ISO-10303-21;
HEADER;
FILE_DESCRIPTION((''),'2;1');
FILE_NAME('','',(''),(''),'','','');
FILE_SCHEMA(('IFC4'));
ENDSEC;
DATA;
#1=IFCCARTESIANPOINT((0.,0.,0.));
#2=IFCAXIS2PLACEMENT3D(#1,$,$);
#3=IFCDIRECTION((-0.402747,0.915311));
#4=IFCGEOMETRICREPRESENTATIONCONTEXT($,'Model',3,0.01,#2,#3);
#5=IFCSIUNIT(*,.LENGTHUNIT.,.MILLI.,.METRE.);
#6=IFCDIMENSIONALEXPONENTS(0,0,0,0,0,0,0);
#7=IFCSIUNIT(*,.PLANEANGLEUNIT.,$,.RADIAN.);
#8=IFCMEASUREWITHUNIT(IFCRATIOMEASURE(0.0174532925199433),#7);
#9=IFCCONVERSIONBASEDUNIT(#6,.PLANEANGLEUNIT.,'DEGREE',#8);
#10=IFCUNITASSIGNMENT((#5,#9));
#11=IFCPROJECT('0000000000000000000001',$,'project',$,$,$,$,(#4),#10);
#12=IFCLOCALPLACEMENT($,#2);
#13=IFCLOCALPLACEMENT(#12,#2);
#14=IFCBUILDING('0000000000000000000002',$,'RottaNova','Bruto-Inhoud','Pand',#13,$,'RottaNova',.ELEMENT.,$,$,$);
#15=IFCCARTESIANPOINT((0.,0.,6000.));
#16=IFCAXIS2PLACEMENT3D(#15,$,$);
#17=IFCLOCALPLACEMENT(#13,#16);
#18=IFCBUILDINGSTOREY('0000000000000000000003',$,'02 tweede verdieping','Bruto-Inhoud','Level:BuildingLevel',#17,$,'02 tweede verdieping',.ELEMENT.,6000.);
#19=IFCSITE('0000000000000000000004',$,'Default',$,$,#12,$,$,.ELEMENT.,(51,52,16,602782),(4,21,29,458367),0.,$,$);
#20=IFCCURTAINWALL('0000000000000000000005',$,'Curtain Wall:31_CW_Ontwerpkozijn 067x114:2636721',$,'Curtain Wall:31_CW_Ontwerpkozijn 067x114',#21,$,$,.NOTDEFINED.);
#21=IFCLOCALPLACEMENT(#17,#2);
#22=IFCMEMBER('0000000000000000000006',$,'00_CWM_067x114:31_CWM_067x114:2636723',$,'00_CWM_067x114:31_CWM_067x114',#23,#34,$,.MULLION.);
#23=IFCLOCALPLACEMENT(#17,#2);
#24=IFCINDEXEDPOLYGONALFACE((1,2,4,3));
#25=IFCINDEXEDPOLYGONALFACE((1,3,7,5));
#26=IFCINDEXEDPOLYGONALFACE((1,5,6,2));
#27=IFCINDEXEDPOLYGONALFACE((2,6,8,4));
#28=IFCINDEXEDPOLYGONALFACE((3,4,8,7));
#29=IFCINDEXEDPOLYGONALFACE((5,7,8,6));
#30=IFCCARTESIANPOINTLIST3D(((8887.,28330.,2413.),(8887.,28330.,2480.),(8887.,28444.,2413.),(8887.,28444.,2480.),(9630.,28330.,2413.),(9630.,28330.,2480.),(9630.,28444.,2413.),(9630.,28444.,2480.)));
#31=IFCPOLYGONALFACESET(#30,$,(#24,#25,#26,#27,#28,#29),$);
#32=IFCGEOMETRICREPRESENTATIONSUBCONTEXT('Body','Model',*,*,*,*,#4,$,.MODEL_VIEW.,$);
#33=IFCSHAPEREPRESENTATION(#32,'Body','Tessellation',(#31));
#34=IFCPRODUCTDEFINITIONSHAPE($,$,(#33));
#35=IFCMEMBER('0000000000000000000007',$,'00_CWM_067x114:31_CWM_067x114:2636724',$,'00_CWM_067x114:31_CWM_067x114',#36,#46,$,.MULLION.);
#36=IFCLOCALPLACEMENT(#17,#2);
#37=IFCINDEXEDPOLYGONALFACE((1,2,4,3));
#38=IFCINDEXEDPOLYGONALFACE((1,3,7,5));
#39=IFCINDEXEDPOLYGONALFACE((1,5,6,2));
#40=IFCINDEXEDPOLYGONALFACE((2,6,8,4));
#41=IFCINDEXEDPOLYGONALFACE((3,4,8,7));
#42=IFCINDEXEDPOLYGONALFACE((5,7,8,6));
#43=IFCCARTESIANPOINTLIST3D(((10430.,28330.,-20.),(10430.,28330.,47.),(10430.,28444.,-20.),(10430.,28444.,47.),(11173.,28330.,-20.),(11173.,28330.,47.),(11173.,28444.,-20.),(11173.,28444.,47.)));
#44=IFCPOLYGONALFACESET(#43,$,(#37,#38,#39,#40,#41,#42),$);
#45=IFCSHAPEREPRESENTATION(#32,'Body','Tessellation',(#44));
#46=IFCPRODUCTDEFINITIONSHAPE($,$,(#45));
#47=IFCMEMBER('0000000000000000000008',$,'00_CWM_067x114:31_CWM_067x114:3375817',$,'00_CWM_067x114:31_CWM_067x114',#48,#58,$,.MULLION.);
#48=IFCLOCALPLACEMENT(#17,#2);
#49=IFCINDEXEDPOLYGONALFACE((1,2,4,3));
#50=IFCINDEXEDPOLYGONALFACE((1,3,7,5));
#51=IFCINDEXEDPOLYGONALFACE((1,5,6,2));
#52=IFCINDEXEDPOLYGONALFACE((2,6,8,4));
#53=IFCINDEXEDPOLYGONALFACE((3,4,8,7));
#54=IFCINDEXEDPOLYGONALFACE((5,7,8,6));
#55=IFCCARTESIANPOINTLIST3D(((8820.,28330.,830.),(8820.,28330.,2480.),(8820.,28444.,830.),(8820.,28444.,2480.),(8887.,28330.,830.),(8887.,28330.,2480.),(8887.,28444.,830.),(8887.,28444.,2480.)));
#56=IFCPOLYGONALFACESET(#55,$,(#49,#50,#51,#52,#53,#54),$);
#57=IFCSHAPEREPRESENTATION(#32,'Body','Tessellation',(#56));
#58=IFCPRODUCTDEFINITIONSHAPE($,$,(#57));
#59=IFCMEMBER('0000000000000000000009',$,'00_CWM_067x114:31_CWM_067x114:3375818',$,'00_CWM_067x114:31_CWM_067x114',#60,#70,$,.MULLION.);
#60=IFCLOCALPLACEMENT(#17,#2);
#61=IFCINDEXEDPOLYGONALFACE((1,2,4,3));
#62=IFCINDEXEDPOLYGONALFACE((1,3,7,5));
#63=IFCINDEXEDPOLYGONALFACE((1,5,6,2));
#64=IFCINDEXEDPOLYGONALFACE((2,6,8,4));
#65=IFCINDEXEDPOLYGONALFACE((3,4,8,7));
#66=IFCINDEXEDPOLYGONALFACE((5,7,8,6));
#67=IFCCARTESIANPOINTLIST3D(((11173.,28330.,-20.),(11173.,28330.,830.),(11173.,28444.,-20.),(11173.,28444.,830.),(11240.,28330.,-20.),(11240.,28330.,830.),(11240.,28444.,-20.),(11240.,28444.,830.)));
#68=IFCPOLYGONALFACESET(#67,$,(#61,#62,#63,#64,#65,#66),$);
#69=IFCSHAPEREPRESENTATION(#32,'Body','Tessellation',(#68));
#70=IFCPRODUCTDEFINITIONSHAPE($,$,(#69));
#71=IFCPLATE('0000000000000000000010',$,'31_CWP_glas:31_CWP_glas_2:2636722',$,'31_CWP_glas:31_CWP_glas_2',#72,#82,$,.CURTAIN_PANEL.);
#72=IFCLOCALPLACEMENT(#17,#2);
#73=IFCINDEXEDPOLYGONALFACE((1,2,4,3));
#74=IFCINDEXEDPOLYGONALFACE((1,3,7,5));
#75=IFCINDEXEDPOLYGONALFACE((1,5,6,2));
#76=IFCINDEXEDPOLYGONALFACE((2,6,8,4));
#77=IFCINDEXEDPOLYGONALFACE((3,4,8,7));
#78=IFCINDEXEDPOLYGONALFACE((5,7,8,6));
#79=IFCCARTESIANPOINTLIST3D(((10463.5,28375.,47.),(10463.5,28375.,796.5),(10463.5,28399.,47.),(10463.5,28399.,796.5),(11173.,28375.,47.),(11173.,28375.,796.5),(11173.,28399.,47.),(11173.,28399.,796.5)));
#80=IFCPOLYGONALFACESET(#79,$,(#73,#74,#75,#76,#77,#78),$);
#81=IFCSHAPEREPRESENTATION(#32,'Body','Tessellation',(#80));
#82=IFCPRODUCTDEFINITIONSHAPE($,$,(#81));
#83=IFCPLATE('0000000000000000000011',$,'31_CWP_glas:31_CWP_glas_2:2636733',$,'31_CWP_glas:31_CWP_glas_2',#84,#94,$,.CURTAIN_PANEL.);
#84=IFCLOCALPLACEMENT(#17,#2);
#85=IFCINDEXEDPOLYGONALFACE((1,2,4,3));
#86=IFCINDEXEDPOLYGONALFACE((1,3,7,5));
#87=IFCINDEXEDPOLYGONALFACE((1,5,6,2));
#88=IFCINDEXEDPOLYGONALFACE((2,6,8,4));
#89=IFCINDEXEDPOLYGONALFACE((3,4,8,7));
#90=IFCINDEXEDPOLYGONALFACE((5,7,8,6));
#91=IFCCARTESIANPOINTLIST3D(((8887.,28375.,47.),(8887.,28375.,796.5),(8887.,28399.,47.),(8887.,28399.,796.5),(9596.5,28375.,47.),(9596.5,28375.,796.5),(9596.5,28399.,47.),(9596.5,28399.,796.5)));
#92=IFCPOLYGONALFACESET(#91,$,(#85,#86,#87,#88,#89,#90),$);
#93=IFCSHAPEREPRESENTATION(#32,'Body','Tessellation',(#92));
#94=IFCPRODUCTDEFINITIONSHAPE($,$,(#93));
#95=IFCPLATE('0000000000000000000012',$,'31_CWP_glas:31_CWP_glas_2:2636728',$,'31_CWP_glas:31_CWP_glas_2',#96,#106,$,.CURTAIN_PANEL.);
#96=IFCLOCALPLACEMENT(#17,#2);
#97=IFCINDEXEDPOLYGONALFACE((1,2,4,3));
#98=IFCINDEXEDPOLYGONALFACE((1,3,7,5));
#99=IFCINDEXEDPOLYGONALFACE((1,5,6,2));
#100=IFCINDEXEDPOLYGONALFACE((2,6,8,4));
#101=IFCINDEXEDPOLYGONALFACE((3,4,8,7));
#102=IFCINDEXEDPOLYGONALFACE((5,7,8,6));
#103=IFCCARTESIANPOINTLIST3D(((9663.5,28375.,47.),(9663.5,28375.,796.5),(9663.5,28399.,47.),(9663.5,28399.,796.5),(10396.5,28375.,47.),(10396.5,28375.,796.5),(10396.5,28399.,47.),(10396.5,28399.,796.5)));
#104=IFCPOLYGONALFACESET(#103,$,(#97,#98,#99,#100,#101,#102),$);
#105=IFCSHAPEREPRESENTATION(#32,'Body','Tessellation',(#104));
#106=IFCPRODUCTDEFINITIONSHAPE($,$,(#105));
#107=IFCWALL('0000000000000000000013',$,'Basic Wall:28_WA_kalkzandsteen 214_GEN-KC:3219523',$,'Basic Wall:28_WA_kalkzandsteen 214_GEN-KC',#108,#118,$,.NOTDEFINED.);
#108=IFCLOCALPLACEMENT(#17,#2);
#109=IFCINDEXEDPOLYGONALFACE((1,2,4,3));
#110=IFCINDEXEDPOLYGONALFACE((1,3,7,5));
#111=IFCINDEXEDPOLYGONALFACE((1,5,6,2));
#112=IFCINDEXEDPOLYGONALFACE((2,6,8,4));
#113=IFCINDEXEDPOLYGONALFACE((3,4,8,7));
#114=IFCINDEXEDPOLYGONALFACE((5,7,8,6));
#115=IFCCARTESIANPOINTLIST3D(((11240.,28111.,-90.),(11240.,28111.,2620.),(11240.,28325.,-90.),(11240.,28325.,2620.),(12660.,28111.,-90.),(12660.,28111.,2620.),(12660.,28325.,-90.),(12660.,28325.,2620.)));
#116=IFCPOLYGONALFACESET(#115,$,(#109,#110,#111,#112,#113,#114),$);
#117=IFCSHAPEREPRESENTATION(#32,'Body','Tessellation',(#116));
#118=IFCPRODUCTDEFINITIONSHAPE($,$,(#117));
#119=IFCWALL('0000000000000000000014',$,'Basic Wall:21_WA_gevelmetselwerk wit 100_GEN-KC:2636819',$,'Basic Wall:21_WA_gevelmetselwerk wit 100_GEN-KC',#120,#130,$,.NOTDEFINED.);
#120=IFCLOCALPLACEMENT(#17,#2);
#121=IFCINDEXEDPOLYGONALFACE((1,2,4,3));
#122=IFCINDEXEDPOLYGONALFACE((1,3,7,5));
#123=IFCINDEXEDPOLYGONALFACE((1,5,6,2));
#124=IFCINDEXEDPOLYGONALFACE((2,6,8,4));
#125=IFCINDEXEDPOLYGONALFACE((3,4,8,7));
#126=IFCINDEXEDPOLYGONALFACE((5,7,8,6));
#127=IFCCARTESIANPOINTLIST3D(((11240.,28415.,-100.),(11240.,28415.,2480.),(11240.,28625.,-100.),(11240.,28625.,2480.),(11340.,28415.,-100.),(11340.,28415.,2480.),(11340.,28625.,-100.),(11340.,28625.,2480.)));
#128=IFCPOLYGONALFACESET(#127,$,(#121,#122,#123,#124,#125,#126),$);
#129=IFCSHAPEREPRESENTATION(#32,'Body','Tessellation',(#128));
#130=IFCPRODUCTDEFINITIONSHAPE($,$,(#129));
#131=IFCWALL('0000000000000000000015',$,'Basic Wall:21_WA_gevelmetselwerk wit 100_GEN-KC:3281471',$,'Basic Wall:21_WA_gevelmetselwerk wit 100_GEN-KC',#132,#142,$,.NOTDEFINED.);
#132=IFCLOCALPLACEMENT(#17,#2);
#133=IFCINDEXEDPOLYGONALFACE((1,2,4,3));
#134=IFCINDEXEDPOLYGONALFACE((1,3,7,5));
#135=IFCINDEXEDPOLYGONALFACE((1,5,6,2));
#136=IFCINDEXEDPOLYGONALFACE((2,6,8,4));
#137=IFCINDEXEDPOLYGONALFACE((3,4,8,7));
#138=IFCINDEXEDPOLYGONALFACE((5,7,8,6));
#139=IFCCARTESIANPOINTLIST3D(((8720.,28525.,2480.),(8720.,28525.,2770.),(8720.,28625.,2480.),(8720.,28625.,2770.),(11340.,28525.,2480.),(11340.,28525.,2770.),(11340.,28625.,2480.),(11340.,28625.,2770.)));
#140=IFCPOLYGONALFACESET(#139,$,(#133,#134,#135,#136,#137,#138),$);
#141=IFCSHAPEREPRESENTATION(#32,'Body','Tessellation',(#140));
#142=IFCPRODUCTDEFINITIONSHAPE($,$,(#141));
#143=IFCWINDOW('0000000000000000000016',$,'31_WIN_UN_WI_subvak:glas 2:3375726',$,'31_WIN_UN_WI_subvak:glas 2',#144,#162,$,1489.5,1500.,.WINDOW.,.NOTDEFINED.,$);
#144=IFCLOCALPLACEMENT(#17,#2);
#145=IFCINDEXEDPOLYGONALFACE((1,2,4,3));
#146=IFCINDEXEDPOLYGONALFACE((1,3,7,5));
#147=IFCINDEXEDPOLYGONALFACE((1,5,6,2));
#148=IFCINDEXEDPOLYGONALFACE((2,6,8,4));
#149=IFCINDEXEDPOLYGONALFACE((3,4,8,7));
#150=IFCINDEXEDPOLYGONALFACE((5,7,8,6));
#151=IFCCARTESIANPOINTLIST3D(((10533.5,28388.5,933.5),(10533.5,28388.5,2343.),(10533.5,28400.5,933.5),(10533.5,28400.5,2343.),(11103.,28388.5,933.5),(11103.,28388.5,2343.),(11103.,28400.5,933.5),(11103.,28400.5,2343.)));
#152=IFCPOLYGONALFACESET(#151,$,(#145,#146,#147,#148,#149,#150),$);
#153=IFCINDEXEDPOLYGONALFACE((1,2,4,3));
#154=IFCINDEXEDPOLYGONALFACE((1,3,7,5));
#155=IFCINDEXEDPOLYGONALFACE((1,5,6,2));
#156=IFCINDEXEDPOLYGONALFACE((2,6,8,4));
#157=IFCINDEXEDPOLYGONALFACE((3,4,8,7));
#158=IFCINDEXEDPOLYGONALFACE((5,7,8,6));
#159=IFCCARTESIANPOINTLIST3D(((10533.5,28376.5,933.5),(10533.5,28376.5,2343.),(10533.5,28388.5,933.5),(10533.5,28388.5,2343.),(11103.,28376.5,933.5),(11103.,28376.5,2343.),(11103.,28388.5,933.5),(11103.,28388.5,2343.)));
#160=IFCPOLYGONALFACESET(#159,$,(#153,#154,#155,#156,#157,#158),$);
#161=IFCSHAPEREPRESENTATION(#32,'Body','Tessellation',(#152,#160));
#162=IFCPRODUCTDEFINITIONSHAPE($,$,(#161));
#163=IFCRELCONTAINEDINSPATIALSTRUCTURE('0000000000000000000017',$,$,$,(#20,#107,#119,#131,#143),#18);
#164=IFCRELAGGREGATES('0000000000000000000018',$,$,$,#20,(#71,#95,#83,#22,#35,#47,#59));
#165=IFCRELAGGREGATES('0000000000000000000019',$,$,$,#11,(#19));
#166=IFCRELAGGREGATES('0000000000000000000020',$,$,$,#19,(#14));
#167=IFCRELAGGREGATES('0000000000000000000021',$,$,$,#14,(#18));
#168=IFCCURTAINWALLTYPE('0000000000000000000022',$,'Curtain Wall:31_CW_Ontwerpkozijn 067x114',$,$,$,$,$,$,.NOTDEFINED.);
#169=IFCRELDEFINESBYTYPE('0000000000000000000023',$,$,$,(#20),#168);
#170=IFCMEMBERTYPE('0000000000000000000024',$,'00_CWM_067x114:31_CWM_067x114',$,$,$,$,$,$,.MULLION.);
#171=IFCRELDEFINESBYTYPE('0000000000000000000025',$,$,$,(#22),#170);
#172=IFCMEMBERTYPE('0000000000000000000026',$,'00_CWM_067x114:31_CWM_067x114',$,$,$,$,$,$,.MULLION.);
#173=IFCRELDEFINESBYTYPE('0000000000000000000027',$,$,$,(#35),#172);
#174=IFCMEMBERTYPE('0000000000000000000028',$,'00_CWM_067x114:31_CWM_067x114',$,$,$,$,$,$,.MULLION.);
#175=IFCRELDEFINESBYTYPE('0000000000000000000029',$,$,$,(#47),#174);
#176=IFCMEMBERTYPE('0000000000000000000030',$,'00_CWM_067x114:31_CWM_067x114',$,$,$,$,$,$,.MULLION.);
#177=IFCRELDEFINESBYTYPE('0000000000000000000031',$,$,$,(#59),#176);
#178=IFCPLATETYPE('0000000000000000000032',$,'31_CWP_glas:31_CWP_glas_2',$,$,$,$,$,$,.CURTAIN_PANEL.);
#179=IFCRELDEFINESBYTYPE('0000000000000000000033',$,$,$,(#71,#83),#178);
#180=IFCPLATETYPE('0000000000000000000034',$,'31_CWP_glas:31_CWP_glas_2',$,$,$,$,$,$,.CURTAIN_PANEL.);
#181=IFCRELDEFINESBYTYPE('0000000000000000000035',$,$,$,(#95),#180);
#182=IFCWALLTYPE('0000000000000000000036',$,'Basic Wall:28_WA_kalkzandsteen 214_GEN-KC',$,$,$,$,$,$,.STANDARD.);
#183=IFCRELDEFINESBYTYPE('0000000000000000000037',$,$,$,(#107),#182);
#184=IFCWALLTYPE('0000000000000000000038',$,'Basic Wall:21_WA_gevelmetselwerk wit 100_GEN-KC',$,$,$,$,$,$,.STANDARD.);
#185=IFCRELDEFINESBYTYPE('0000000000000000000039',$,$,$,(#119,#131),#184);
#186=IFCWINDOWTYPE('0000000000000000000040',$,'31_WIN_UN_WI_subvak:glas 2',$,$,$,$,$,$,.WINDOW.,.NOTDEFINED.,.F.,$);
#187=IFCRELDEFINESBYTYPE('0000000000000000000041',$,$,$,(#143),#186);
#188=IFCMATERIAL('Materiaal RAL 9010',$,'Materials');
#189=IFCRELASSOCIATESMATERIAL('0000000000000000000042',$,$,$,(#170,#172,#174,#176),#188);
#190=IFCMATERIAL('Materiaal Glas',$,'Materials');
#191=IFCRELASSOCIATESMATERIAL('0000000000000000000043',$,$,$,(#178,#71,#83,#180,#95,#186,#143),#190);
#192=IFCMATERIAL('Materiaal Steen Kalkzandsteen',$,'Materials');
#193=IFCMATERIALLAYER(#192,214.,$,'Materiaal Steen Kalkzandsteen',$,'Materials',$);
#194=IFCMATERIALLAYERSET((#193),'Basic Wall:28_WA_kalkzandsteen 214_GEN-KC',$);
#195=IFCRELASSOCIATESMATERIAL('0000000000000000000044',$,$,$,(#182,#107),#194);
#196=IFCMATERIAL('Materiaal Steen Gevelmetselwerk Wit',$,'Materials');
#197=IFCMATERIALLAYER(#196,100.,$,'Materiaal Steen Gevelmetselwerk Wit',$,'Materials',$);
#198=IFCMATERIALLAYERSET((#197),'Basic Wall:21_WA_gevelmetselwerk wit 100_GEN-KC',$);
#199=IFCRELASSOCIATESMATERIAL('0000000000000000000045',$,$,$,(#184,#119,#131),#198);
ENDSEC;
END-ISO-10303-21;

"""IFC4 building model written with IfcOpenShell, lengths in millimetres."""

from ifc_helpers import new_model, entity, si_unit, converted_unit, direction, frame, frame_2d, origin, origin_2d_with_axis, place, context, subcontext, project, spatial, rectangle, extrude, source, transform, mapped, material, layer, layer_set, material_profile, profile_set, type_object, type_shapes, element, aggregate, save


model = new_model("IFC4")

# Units and contexts
model_context = context("Model", 3, precision=0.01, world=origin(), true_north=direction((-0.402747, 0.915311)))
body_context = subcontext(model_context, "Body", "Model", "MODEL_VIEW")
ifc_project = project(units=[si_unit("LENGTHUNIT", "METRE", prefix="MILLI"), converted_unit("PLANEANGLEUNIT", "DEGREE", entity("IfcRatioMeasure", 0.0174532925199433), si_unit("PLANEANGLEUNIT", "RADIAN"), dimensions=[0, 0, 0, 0, 0, 0, 0])], contexts=[model_context])

# Site, building, storey
site_placement = place(None, origin())
site = spatial("IfcSite", under=ifc_project, at=site_placement, Name="Default", CompositionType="ELEMENT", RefLatitude=(51, 52, 16, 602782), RefLongitude=(4, 21, 29, 458367), RefElevation=0.0)
building_placement = place(site_placement, origin())
building = spatial("IfcBuilding", under=site, at=building_placement, Name="RottaNova", Description="Bruto-Inhoud", ObjectType="Pand", LongName="RottaNova", CompositionType="ELEMENT")
storey_placement = place(building_placement, frame((0.0, 0.0, 6000.0)))
storey = spatial("IfcBuildingStorey", under=building, at=storey_placement, Name="02 tweede verdieping", Description="Bruto-Inhoud", ObjectType="Level:BuildingLevel", LongName="02 tweede verdieping", CompositionType="ELEMENT", Elevation=6000.0)

# Curtain wall, members, plates
curtain_wall_type = type_object("IfcCurtainWallType", Name="Curtain Wall:31_CW_Ontwerpkozijn 067x114", PredefinedType="NOTDEFINED")
curtain_wall_placement = place(storey_placement, frame((0.0, 0.0, -6000.0)))
curtain_wall = element("IfcCurtainWall", 1, at=curtain_wall_placement, inside=storey, type_object=curtain_wall_type, Name="Curtain Wall:31_CW_Ontwerpkozijn 067x114:2636721", ObjectType="Curtain Wall:31_CW_Ontwerpkozijn 067x114", PredefinedType="NOTDEFINED")
ifc_material_1 = material(Name="Materiaal RAL 9010", Category="Materials")
ifc_material_profile = material_profile(ifc_material_1, rectangle(XDim=114.0, YDim=67.0, at=origin_2d_with_axis()), Name="31_CWM_067x114")
ifc_profile_set = profile_set([ifc_material_profile], Name="31_CWM_067x114")
member_type_1 = type_object("IfcMemberType", Name="00_CWM_067x114:31_CWM_067x114", PredefinedType="MULLION", material=ifc_profile_set)
shared_shape_1 = source(origin(), body_context, "Body", "SweptSolid", [
    extrude(rectangle(XDim=114.0, YDim=67.0, at=origin_2d_with_axis()), frame((-33.5, 57.0, -743.0), z_axis=(0.0, 0.0, 1.0), x_axis=(0.0, -1.0, 0.0)), (0.0, 0.0, 1.0), 743.0),
])
type_shapes(member_type_1, [shared_shape_1])
member_1_placement = place(curtain_wall_placement, frame((8887.0, 28330.0, 8480.0), z_axis=(-1.0, 0.0, 0.0), x_axis=(0.0, 0.0, 1.0)))
member_1 = element("IfcMember", 2, at=member_1_placement, type_object=member_type_1, Name="00_CWM_067x114:31_CWM_067x114:2636723", ObjectType="00_CWM_067x114:31_CWM_067x114", PredefinedType="MULLION", context=body_context, shape_type="MappedRepresentation", body=[
    mapped(shared_shape_1, transform((0.0, 0.0, 0.0), scale=1.0)),
])
member_type_2 = type_object("IfcMemberType", Name="00_CWM_067x114:31_CWM_067x114", PredefinedType="MULLION", material=ifc_profile_set)
shared_shape_2 = source(origin(), body_context, "Body", "SweptSolid", [
    extrude(rectangle(XDim=114.0, YDim=67.0, at=origin_2d_with_axis()), frame((-33.5, 57.0, -743.0), z_axis=(0.0, 0.0, 1.0), x_axis=(0.0, -1.0, 0.0)), (0.0, 0.0, 1.0), 743.0),
])
type_shapes(member_type_2, [shared_shape_2])
member_2_placement = place(curtain_wall_placement, frame((11173.0, 28330.0, 5980.0), z_axis=(1.0, 0.0, 0.0), x_axis=(0.0, 0.0, -1.0)))
member_2 = element("IfcMember", 3, at=member_2_placement, type_object=member_type_2, Name="00_CWM_067x114:31_CWM_067x114:2636724", ObjectType="00_CWM_067x114:31_CWM_067x114", PredefinedType="MULLION", context=body_context, shape_type="MappedRepresentation", body=[
    mapped(shared_shape_2, transform((0.0, 0.0, 0.0), scale=1.0)),
])
member_type_3 = type_object("IfcMemberType", Name="00_CWM_067x114:31_CWM_067x114", PredefinedType="MULLION", material=ifc_profile_set)
shared_shape_3 = source(origin(), body_context, "Body", "SweptSolid", [
    extrude(rectangle(XDim=114.0, YDim=67.0, at=origin_2d_with_axis()), frame((-33.5, 57.0, -1650.0), z_axis=(0.0, 0.0, 1.0), x_axis=(0.0, -1.0, 0.0)), (0.0, 0.0, 1.0), 1650.0),
])
type_shapes(member_type_3, [shared_shape_3])
member_3_placement = place(curtain_wall_placement, frame((8820.0, 28330.0, 6830.0), z_axis=(0.0, 0.0, -1.0), x_axis=(-1.0, 0.0, 0.0)))
member_3 = element("IfcMember", 4, at=member_3_placement, type_object=member_type_3, Name="00_CWM_067x114:31_CWM_067x114:3375817", ObjectType="00_CWM_067x114:31_CWM_067x114", PredefinedType="MULLION", context=body_context, shape_type="MappedRepresentation", body=[
    mapped(shared_shape_3, transform((0.0, 0.0, 0.0), scale=1.0)),
])
member_type_4 = type_object("IfcMemberType", Name="00_CWM_067x114:31_CWM_067x114", PredefinedType="MULLION", material=ifc_profile_set)
shared_shape_4 = source(origin(), body_context, "Body", "SweptSolid", [
    extrude(rectangle(XDim=114.0, YDim=67.0, at=origin_2d_with_axis()), frame((-33.5, 57.0, -850.0), z_axis=(0.0, 0.0, 1.0), x_axis=(0.0, -1.0, 0.0)), (0.0, 0.0, 1.0), 850.0),
])
type_shapes(member_type_4, [shared_shape_4])
member_4_placement = place(curtain_wall_placement, frame((11240.0, 28330.0, 6830.0)))
member_4 = element("IfcMember", 5, at=member_4_placement, type_object=member_type_4, Name="00_CWM_067x114:31_CWM_067x114:3375818", ObjectType="00_CWM_067x114:31_CWM_067x114", PredefinedType="MULLION", context=body_context, shape_type="MappedRepresentation", body=[
    mapped(shared_shape_4, transform((0.0, 0.0, 0.0), scale=1.0)),
])
ifc_material_2 = material(Name="Materiaal Glas", Category="Materials")
plate_type_1 = type_object("IfcPlateType", Name="31_CWP_glas:31_CWP_glas_2", PredefinedType="CURTAIN_PANEL", material=ifc_material_2)
shared_shape_5 = source(origin(), body_context, "Body", "SweptSolid", [
    extrude(rectangle(XDim=24.0, YDim=709.5, at=frame_2d((0.0, 0.0), x_axis=(1.0, 0.0))), frame((354.8, 12.0, 0.0), z_axis=(0.0, 0.0, 1.0), x_axis=(0.0, 1.0, 0.0)), (0.0, 0.0, 1.0), 749.5),
])
type_shapes(plate_type_1, [shared_shape_5])
plate_1_placement = place(curtain_wall_placement, frame((11173.0, 28399.0, 6047.0), z_axis=(0.0, 0.0, 1.0), x_axis=(-1.0, 0.0, 0.0)))
plate_1 = element("IfcPlate", 6, at=plate_1_placement, type_object=plate_type_1, material=ifc_material_2, Name="31_CWP_glas:31_CWP_glas_2:2636722", ObjectType="31_CWP_glas:31_CWP_glas_2", PredefinedType="CURTAIN_PANEL", context=body_context, shape_type="MappedRepresentation", body=[
    mapped(shared_shape_5, transform((0.0, 0.0, 0.0), scale=1.0)),
])
plate_2_placement = place(curtain_wall_placement, frame((9596.5, 28399.0, 6047.0), z_axis=(0.0, 0.0, 1.0), x_axis=(-1.0, 0.0, 0.0)))
plate_2 = element("IfcPlate", 7, at=plate_2_placement, type_object=plate_type_1, material=ifc_material_2, Name="31_CWP_glas:31_CWP_glas_2:2636733", ObjectType="31_CWP_glas:31_CWP_glas_2", PredefinedType="CURTAIN_PANEL", context=body_context, shape_type="MappedRepresentation", body=[
    mapped(shared_shape_5, transform((0.0, 0.0, 0.0), scale=1.0)),
])
plate_type_2 = type_object("IfcPlateType", Name="31_CWP_glas:31_CWP_glas_2", PredefinedType="CURTAIN_PANEL", material=ifc_material_2)
shared_shape_6 = source(origin(), body_context, "Body", "SweptSolid", [
    extrude(rectangle(XDim=24.0, YDim=733.0, at=frame_2d((0.0, 0.0), x_axis=(1.0, 0.0))), frame((366.5, 12.0, 0.0), z_axis=(0.0, 0.0, 1.0), x_axis=(0.0, 1.0, 0.0)), (0.0, 0.0, 1.0), 749.5),
])
type_shapes(plate_type_2, [shared_shape_6])
plate_3_placement = place(curtain_wall_placement, frame((10396.5, 28399.0, 6047.0), z_axis=(0.0, 0.0, 1.0), x_axis=(-1.0, 0.0, 0.0)))
plate_3 = element("IfcPlate", 8, at=plate_3_placement, type_object=plate_type_2, material=ifc_material_2, Name="31_CWP_glas:31_CWP_glas_2:2636728", ObjectType="31_CWP_glas:31_CWP_glas_2", PredefinedType="CURTAIN_PANEL", context=body_context, shape_type="MappedRepresentation", body=[
    mapped(shared_shape_6, transform((0.0, 0.0, 0.0), scale=1.0)),
])

# Walls
ifc_material_3 = material(Name="Materiaal Steen Kalkzandsteen", Category="Materials")
ifc_layer_1 = layer(ifc_material_3, 214.0, Name="Materiaal Steen Kalkzandsteen", Category="Materials")
ifc_layer_set_1 = layer_set([ifc_layer_1], Name="Basic Wall:28_WA_kalkzandsteen 214_GEN-KC")
wall_type_1 = type_object("IfcWallType", Name="Basic Wall:28_WA_kalkzandsteen 214_GEN-KC", PredefinedType="STANDARD", material=ifc_layer_set_1)
wall_1_placement = place(storey_placement, frame((11240.0, 28218.0, -90.0)))
element("IfcWall", 9, at=wall_1_placement, inside=storey, type_object=wall_type_1, material=ifc_layer_set_1, Name="Basic Wall:28_WA_kalkzandsteen 214_GEN-KC:3219523", ObjectType="Basic Wall:28_WA_kalkzandsteen 214_GEN-KC", PredefinedType="NOTDEFINED", context=body_context, shape_type="SweptSolid", body=[
    extrude(rectangle(XDim=1420.0, YDim=214.0, at=frame_2d((710.0, 0.0), x_axis=(-1.0, 0.0))), origin(), (0.0, 0.0, 1.0), 2710.0),
])
ifc_material_4 = material(Name="Materiaal Steen Gevelmetselwerk Wit", Category="Materials")
ifc_layer_2 = layer(ifc_material_4, 100.0, Name="Materiaal Steen Gevelmetselwerk Wit", Category="Materials")
ifc_layer_set_2 = layer_set([ifc_layer_2], Name="Basic Wall:21_WA_gevelmetselwerk wit 100_GEN-KC")
wall_type_2 = type_object("IfcWallType", Name="Basic Wall:21_WA_gevelmetselwerk wit 100_GEN-KC", PredefinedType="STANDARD", material=ifc_layer_set_2)
wall_2_placement = place(storey_placement, frame((11290.0, 28415.0, -100.0), z_axis=(0.0, 0.0, 1.0), x_axis=(0.0, 1.0, 0.0)))
element("IfcWall", 10, at=wall_2_placement, inside=storey, type_object=wall_type_2, material=ifc_layer_set_2, Name="Basic Wall:21_WA_gevelmetselwerk wit 100_GEN-KC:2636819", ObjectType="Basic Wall:21_WA_gevelmetselwerk wit 100_GEN-KC", PredefinedType="NOTDEFINED", context=body_context, shape_type="SweptSolid", body=[
    extrude(rectangle(XDim=210.0, YDim=100.0, at=frame_2d((105.0, 0.0), x_axis=(-1.0, 0.0))), origin(), (0.0, 0.0, 1.0), 2580.0),
])

# Wall
wall_3_placement = place(storey_placement, frame((11340.0, 28575.0, 2480.0), z_axis=(0.0, 0.0, 1.0), x_axis=(-1.0, 0.0, 0.0)))
element("IfcWall", 11, at=wall_3_placement, inside=storey, type_object=wall_type_2, material=ifc_layer_set_2, Name="Basic Wall:21_WA_gevelmetselwerk wit 100_GEN-KC:3281471", ObjectType="Basic Wall:21_WA_gevelmetselwerk wit 100_GEN-KC", PredefinedType="NOTDEFINED", context=body_context, shape_type="SweptSolid", body=[
    extrude(rectangle(XDim=2620.0, YDim=100.0, at=frame_2d((1310.0, 0.0), x_axis=(-1.0, 0.0))), origin(), (0.0, 0.0, 1.0), 290.0),
])

# Window
window_type_1 = type_object("IfcWindowType", Name="31_WIN_UN_WI_subvak:glas 2", ParameterTakesPrecedence=False, PartitioningType="NOTDEFINED", PredefinedType="WINDOW", material=ifc_material_2)
shared_shape_7 = source(origin(), body_context, "Body", "SweptSolid", [
    extrude(rectangle(XDim=569.5, YDim=12.0, at=origin_2d_with_axis()), frame((0.0, -6.0, 0.0)), (0.0, 0.0, 1.0), 1409.5),
    extrude(rectangle(XDim=569.5, YDim=12.0, at=origin_2d_with_axis()), frame((0.0, 6.0, 0.0)), (0.0, 0.0, 1.0), 1409.5),
])
type_shapes(window_type_1, [shared_shape_7])
for number, where, z_axis, x_axis, name in (
    (12, (10818.2, 28388.5, 933.5), (0.0, 0.0, 1.0), (-1.0, 0.0, 0.0), "31_WIN_UN_WI_subvak:glas 2:3375726"),
):
    element("IfcWindow", number, at=place(storey_placement, frame(where, z_axis=z_axis, x_axis=x_axis)), inside=storey, type_object=window_type_1, material=ifc_material_2, Name=name, ObjectType="31_WIN_UN_WI_subvak:glas 2", OverallHeight=1489.5, OverallWidth=1500.0, PartitioningType="NOTDEFINED", PredefinedType="WINDOW", context=body_context, shape_type="MappedRepresentation", body=[
        mapped(shared_shape_7, transform((0.0, 0.0, 0.0), scale=1.0)),
    ])

aggregate(curtain_wall, [plate_1, plate_3, plate_2, member_1, member_2, member_3, member_4])

save(model, "model.ifc")
